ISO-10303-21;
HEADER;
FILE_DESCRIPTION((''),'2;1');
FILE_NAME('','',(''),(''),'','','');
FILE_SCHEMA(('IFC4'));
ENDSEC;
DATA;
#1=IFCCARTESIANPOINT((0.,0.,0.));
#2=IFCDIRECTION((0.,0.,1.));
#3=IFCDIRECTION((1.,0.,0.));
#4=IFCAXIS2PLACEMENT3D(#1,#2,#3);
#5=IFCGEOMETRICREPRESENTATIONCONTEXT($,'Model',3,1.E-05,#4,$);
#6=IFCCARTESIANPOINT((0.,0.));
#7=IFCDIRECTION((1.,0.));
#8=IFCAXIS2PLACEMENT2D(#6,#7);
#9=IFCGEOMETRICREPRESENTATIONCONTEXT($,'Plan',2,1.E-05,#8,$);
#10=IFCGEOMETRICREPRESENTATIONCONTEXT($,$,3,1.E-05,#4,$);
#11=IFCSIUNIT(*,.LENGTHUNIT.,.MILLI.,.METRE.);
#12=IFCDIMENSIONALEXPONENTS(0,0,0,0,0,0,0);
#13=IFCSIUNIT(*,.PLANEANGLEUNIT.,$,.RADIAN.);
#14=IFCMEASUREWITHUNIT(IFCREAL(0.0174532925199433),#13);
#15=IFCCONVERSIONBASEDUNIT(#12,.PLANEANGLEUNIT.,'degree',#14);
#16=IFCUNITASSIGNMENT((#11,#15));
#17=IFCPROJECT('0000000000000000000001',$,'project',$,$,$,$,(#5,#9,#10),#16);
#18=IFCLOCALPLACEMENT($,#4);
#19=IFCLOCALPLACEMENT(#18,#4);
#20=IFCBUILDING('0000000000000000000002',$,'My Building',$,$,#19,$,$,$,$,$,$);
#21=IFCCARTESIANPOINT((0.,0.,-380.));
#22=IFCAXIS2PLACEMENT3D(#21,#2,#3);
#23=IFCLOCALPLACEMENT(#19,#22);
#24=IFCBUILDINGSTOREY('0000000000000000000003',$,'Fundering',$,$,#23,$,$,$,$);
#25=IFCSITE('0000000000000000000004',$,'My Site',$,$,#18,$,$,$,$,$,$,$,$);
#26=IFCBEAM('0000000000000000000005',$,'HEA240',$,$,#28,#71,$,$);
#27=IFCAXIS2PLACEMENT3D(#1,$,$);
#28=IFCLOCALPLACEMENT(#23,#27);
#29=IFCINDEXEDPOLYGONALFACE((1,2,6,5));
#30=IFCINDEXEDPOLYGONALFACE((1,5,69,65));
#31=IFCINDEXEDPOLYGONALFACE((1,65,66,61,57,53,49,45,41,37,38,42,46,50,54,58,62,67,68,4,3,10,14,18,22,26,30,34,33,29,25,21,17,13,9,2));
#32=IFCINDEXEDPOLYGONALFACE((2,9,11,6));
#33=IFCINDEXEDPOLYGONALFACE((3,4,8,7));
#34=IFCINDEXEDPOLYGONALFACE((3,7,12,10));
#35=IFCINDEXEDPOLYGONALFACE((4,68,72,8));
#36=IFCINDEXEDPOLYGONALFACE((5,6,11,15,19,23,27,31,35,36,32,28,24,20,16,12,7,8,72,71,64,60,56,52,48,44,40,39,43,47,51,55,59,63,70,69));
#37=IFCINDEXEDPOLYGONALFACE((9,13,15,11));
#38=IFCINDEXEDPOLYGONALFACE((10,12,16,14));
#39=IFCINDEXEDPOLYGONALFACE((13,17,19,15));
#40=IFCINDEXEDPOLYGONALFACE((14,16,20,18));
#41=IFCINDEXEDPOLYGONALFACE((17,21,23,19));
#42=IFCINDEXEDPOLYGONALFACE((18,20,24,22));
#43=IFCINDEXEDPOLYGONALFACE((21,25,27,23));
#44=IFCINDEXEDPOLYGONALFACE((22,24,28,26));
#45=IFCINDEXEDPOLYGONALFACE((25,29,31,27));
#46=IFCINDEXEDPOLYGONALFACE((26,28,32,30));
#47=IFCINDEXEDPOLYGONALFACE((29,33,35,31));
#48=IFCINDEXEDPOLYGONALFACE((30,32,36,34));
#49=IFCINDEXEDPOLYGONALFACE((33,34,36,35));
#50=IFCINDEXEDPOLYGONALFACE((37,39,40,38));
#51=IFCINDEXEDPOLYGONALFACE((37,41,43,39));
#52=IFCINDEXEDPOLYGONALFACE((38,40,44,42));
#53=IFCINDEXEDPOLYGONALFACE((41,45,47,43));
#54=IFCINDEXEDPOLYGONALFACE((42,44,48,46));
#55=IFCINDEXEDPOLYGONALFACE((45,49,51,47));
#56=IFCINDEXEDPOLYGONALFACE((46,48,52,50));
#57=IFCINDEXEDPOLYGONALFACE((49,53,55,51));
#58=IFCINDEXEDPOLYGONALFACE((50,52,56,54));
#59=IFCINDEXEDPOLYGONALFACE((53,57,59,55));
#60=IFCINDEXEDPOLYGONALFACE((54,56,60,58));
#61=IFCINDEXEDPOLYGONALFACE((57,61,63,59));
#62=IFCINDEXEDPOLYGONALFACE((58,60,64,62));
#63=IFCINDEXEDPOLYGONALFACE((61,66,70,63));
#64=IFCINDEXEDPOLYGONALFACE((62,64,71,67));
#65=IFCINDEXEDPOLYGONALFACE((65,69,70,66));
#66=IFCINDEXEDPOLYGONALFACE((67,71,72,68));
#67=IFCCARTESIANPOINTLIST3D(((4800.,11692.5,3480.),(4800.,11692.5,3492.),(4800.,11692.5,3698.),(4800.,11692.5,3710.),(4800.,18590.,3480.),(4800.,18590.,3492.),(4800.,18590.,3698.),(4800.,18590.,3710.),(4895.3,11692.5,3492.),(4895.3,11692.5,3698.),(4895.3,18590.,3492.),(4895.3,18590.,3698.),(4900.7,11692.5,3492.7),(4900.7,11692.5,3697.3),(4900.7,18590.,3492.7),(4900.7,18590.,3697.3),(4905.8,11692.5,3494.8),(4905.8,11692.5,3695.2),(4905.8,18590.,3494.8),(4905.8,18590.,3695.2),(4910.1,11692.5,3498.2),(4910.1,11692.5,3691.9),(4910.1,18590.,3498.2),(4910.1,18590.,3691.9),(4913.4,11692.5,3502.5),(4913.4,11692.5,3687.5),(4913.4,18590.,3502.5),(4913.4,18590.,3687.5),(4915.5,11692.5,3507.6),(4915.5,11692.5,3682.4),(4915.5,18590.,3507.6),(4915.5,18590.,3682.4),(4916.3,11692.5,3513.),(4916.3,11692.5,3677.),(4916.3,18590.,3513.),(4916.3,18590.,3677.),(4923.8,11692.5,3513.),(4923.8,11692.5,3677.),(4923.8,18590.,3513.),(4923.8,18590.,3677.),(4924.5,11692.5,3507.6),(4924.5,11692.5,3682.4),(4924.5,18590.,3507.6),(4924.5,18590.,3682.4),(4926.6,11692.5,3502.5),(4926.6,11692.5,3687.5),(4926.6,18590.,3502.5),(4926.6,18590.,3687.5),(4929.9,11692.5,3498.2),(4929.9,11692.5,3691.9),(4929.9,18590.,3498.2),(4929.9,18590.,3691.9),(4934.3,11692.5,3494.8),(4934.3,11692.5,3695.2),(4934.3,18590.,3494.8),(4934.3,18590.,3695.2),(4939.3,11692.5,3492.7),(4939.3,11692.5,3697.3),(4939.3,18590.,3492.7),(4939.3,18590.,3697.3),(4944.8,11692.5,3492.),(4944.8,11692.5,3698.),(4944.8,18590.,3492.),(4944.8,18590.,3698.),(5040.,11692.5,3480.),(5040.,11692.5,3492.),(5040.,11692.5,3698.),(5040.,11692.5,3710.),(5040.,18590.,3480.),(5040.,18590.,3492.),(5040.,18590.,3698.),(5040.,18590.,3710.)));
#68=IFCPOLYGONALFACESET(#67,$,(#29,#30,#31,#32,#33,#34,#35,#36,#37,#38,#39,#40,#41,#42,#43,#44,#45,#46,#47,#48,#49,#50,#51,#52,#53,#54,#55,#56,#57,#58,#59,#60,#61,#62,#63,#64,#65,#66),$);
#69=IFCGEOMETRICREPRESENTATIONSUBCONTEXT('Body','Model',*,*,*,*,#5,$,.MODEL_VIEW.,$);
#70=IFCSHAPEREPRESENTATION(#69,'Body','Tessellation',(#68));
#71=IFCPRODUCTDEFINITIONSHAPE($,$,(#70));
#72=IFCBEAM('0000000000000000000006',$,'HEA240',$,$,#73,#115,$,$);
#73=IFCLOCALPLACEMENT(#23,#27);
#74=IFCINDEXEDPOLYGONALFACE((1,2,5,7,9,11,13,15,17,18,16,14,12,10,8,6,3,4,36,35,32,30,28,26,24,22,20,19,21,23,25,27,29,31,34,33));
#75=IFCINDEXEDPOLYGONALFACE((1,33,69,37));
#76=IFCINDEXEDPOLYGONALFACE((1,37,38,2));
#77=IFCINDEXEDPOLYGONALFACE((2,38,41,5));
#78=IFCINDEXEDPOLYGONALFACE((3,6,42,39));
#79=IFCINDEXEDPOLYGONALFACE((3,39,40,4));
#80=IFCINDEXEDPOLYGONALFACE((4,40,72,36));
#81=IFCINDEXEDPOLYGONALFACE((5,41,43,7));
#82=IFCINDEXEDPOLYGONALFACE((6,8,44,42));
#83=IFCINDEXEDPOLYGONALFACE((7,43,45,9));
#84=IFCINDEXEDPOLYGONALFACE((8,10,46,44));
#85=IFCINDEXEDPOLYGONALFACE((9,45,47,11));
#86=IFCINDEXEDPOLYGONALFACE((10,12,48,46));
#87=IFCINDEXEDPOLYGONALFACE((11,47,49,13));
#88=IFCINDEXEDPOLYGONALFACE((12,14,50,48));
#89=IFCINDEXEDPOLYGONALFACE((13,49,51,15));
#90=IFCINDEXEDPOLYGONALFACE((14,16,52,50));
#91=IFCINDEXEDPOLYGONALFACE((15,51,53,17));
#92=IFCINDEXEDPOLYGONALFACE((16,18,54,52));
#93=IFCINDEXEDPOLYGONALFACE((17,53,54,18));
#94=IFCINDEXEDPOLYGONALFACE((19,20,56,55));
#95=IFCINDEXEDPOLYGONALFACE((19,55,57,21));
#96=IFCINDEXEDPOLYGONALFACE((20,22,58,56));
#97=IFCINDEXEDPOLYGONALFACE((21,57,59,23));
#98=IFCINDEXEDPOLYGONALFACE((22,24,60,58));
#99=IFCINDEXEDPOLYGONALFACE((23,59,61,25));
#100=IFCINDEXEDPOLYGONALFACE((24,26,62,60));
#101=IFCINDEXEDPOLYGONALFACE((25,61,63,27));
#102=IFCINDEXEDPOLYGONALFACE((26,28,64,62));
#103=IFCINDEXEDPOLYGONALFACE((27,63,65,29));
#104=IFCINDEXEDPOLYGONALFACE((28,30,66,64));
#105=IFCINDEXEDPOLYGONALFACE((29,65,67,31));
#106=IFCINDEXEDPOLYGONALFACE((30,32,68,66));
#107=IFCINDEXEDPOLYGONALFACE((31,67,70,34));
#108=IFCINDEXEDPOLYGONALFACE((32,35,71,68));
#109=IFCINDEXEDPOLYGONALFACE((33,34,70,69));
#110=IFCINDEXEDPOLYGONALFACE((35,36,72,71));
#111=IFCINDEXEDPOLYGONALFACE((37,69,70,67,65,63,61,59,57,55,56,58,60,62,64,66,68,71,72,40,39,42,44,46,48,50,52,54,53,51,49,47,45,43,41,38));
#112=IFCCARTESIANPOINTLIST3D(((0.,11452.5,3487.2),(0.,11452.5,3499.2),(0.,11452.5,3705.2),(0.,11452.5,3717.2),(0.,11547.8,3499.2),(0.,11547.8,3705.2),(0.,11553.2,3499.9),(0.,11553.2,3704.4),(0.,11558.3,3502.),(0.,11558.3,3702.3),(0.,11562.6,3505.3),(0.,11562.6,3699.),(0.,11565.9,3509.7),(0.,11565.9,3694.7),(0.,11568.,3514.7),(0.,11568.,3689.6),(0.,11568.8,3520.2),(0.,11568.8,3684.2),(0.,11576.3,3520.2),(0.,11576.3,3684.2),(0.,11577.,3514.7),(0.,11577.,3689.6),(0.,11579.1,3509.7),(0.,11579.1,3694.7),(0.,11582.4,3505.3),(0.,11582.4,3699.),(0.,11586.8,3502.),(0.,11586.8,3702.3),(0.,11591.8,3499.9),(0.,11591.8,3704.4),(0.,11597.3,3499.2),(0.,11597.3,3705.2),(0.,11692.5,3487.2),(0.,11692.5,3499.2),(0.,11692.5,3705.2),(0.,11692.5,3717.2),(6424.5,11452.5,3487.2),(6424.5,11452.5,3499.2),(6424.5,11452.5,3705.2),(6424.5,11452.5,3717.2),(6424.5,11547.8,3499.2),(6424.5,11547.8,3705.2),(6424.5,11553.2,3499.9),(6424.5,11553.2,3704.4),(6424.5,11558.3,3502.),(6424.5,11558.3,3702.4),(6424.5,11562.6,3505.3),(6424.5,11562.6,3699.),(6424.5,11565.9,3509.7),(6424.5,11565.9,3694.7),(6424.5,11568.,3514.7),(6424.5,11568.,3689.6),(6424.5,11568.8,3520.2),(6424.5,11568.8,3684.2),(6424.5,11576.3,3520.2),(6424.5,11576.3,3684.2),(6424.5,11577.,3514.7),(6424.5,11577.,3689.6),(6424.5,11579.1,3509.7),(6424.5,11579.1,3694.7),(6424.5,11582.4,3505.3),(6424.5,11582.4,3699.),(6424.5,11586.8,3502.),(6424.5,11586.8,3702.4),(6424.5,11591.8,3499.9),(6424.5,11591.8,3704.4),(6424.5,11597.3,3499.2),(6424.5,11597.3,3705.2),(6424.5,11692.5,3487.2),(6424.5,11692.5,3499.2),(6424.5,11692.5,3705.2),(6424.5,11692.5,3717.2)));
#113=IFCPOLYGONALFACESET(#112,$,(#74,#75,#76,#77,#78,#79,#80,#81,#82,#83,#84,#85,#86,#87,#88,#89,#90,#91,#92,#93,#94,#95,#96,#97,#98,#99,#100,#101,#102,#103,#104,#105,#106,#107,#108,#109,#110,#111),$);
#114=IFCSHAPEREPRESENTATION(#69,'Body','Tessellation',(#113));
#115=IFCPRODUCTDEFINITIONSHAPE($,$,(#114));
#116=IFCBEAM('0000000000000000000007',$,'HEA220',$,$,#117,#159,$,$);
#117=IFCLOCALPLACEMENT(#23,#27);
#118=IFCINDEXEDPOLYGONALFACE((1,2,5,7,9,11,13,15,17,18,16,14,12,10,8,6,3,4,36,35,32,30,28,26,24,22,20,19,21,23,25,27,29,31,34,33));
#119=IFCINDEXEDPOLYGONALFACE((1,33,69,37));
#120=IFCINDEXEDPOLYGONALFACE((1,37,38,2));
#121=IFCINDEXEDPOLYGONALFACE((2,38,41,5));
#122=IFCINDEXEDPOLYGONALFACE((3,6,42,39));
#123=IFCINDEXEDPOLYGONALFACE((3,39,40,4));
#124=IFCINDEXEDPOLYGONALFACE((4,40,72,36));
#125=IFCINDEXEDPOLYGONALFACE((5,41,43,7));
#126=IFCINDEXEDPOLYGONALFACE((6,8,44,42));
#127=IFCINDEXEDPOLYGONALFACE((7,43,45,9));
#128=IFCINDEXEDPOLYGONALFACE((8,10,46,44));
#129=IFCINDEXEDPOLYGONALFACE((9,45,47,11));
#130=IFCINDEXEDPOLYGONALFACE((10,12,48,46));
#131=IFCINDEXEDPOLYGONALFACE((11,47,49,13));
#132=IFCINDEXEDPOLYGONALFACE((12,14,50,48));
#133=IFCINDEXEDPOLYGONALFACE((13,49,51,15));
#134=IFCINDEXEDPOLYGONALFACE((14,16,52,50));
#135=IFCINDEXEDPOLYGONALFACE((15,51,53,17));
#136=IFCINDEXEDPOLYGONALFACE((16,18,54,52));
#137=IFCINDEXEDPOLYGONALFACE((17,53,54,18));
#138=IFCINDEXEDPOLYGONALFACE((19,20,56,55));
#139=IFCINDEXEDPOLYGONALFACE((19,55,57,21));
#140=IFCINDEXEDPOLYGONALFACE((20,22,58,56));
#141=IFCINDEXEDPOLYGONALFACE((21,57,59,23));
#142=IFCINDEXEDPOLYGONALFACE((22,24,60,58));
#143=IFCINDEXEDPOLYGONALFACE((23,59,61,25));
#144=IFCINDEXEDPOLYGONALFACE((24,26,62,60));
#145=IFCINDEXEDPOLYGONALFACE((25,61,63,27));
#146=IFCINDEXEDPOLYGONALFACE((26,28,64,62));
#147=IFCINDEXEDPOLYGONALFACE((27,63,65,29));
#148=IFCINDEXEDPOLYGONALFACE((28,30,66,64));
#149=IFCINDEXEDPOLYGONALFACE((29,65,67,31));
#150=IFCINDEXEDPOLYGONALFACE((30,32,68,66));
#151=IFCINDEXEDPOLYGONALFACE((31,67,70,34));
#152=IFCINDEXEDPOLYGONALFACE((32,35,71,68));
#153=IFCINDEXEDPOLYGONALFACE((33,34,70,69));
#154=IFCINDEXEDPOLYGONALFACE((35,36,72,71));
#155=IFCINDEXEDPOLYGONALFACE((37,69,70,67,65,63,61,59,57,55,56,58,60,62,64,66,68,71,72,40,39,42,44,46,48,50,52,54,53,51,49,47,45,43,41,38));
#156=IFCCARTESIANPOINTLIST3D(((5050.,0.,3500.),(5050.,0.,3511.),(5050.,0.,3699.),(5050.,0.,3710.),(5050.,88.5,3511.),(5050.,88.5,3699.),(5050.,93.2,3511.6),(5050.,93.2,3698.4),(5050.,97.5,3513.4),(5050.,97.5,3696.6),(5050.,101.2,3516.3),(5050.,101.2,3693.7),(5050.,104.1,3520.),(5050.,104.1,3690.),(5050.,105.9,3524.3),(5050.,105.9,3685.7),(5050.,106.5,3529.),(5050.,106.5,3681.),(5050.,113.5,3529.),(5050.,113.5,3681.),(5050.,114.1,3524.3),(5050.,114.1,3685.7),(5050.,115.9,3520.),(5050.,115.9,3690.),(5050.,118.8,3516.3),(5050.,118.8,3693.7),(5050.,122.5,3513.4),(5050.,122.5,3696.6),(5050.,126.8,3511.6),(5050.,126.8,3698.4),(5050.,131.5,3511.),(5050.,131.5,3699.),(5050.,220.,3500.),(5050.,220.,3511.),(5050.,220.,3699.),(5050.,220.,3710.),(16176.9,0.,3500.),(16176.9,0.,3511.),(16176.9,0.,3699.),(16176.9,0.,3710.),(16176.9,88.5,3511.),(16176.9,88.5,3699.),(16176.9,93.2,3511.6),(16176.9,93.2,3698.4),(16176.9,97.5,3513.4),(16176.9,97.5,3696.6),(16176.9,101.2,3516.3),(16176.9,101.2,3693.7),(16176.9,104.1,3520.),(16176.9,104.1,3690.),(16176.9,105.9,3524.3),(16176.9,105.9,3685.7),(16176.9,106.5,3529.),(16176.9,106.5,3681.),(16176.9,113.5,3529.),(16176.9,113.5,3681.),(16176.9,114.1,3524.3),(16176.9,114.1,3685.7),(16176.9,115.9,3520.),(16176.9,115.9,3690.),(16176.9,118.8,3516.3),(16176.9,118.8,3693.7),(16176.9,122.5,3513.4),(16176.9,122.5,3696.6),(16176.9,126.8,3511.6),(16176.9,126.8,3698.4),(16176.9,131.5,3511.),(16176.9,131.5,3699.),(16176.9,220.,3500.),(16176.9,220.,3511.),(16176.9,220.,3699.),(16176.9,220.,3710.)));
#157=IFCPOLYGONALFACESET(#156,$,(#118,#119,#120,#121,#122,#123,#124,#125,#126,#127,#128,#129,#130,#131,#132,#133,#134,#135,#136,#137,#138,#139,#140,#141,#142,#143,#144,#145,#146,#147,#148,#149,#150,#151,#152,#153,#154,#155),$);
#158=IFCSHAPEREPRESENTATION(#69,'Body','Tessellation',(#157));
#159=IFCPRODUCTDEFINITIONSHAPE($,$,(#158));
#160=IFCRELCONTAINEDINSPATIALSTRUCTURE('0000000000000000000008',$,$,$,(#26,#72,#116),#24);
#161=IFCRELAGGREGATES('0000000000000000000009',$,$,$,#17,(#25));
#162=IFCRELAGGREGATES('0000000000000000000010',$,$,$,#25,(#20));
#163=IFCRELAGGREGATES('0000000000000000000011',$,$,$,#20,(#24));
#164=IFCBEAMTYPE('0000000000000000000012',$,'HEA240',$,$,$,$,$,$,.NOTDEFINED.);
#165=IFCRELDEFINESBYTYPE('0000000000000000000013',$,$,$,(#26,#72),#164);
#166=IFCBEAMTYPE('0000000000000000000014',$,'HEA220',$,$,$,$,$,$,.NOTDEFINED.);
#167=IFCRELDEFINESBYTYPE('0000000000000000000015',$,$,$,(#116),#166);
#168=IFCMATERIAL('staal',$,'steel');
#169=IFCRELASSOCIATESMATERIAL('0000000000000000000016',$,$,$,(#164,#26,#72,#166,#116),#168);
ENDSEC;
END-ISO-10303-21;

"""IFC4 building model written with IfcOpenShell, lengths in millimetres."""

from ifc_helpers import new_model, entity, si_unit, converted_unit, frame, origin_with_axes, origin_2d_with_axis, place, context, subcontext, project, spatial, i_section, extrude, material, material_profile, profile_set, profile_usage, type_object, element, save


model = new_model("IFC4")

# Units and contexts
model_context = context("Model", 3, precision=1e-05, world=origin_with_axes())
plan_context = context("Plan", 2, precision=1e-05, world=origin_2d_with_axis())
context_of_model = context(None, 3, precision=1e-05, world=origin_with_axes())
body_context = subcontext(model_context, "Body", "Model", "MODEL_VIEW")
ifc_project = project(units=[si_unit("LENGTHUNIT", "METRE", prefix="MILLI"), converted_unit("PLANEANGLEUNIT", "degree", entity("IfcReal", 0.0174532925199433), si_unit("PLANEANGLEUNIT", "RADIAN"), dimensions=[0, 0, 0, 0, 0, 0, 0])], contexts=[model_context, plan_context, context_of_model])

# Site, building, storey
site_placement = place(None, origin_with_axes())
site = spatial("IfcSite", under=ifc_project, at=site_placement, Name="My Site")
building_placement = place(site_placement, origin_with_axes())
building = spatial("IfcBuilding", under=site, at=building_placement, Name="My Building")
storey_placement = place(building_placement, frame((0.0, 0.0, -380.0), z_axis=(0.0, 0.0, 1.0), x_axis=(1.0, 0.0, 0.0)))
storey = spatial("IfcBuildingStorey", under=building, at=storey_placement, Name="Fundering")

# Shared definitions
ifc_material_1 = material(Name="staal", Category="steel")

# Beams
ifc_material_profile_1 = material_profile(ifc_material_1, i_section(OverallWidth=240.0, OverallDepth=230.0, WebThickness=7.5, FlangeThickness=12.0, FilletRadius=21.0))
ifc_profile_set_1 = profile_set([ifc_material_profile_1], Name="HEA240")
beam_type_1 = type_object("IfcBeamType", Name="HEA240", PredefinedType="NOTDEFINED", material=ifc_profile_set_1)
ifc_profile_usage_1 = profile_usage(ifc_profile_set_1, cardinal=5)
beam_1_placement = place(storey_placement, frame((4920.0, 18590.0, 3595.0), z_axis=(0.0, -1.0, 0.0), x_axis=(1.0, 0.0, 0.0)))
element("IfcBeam", 1, at=beam_1_placement, inside=storey, type_object=beam_type_1, material=ifc_profile_usage_1, Name="HEA240", context=body_context, shape_type="SweptSolid", body=[
    extrude(i_section(OverallWidth=240.0, OverallDepth=230.0, WebThickness=7.5, FlangeThickness=12.0, FilletRadius=21.0), origin_with_axes(), (0.0, 0.0, 1.0), 6897.5),
])
ifc_profile_usage_2 = profile_usage(ifc_profile_set_1, cardinal=5)
beam_2_placement = place(storey_placement, frame((0.0, 11572.5, 3602.2), z_axis=(1.0, 0.0, 0.0), x_axis=(0.0, 1.0, 0.0)))
element("IfcBeam", 2, at=beam_2_placement, inside=storey, type_object=beam_type_1, material=ifc_profile_usage_2, Name="HEA240", context=body_context, shape_type="SweptSolid", body=[
    extrude(i_section(OverallWidth=240.0, OverallDepth=230.0, WebThickness=7.5, FlangeThickness=12.0, FilletRadius=21.0), origin_with_axes(), (0.0, 0.0, 1.0), 6424.5),
])
ifc_material_profile_2 = material_profile(ifc_material_1, i_section(OverallWidth=220.0, OverallDepth=210.0, WebThickness=7.0, FlangeThickness=11.0, FilletRadius=18.0))
ifc_profile_set_2 = profile_set([ifc_material_profile_2], Name="HEA220")
ifc_profile_usage_3 = profile_usage(ifc_profile_set_2)
beam_type_2 = type_object("IfcBeamType", Name="HEA220", PredefinedType="NOTDEFINED", material=ifc_profile_set_2)
beam_3_placement = place(storey_placement, frame((5050.0, 110.0, 3605.0), z_axis=(1.0, 0.0, 0.0), x_axis=(0.0, 1.0, 0.0)))
element("IfcBeam", 3, at=beam_3_placement, inside=storey, type_object=beam_type_2, material=ifc_profile_usage_3, Name="HEA220", context=body_context, shape_type="SweptSolid", body=[
    extrude(i_section(OverallWidth=220.0, OverallDepth=210.0, WebThickness=7.0, FlangeThickness=11.0, FilletRadius=18.0), origin_with_axes(), (0.0, 0.0, 1.0), 11126.9),
])

save(model, "model.ifc")
